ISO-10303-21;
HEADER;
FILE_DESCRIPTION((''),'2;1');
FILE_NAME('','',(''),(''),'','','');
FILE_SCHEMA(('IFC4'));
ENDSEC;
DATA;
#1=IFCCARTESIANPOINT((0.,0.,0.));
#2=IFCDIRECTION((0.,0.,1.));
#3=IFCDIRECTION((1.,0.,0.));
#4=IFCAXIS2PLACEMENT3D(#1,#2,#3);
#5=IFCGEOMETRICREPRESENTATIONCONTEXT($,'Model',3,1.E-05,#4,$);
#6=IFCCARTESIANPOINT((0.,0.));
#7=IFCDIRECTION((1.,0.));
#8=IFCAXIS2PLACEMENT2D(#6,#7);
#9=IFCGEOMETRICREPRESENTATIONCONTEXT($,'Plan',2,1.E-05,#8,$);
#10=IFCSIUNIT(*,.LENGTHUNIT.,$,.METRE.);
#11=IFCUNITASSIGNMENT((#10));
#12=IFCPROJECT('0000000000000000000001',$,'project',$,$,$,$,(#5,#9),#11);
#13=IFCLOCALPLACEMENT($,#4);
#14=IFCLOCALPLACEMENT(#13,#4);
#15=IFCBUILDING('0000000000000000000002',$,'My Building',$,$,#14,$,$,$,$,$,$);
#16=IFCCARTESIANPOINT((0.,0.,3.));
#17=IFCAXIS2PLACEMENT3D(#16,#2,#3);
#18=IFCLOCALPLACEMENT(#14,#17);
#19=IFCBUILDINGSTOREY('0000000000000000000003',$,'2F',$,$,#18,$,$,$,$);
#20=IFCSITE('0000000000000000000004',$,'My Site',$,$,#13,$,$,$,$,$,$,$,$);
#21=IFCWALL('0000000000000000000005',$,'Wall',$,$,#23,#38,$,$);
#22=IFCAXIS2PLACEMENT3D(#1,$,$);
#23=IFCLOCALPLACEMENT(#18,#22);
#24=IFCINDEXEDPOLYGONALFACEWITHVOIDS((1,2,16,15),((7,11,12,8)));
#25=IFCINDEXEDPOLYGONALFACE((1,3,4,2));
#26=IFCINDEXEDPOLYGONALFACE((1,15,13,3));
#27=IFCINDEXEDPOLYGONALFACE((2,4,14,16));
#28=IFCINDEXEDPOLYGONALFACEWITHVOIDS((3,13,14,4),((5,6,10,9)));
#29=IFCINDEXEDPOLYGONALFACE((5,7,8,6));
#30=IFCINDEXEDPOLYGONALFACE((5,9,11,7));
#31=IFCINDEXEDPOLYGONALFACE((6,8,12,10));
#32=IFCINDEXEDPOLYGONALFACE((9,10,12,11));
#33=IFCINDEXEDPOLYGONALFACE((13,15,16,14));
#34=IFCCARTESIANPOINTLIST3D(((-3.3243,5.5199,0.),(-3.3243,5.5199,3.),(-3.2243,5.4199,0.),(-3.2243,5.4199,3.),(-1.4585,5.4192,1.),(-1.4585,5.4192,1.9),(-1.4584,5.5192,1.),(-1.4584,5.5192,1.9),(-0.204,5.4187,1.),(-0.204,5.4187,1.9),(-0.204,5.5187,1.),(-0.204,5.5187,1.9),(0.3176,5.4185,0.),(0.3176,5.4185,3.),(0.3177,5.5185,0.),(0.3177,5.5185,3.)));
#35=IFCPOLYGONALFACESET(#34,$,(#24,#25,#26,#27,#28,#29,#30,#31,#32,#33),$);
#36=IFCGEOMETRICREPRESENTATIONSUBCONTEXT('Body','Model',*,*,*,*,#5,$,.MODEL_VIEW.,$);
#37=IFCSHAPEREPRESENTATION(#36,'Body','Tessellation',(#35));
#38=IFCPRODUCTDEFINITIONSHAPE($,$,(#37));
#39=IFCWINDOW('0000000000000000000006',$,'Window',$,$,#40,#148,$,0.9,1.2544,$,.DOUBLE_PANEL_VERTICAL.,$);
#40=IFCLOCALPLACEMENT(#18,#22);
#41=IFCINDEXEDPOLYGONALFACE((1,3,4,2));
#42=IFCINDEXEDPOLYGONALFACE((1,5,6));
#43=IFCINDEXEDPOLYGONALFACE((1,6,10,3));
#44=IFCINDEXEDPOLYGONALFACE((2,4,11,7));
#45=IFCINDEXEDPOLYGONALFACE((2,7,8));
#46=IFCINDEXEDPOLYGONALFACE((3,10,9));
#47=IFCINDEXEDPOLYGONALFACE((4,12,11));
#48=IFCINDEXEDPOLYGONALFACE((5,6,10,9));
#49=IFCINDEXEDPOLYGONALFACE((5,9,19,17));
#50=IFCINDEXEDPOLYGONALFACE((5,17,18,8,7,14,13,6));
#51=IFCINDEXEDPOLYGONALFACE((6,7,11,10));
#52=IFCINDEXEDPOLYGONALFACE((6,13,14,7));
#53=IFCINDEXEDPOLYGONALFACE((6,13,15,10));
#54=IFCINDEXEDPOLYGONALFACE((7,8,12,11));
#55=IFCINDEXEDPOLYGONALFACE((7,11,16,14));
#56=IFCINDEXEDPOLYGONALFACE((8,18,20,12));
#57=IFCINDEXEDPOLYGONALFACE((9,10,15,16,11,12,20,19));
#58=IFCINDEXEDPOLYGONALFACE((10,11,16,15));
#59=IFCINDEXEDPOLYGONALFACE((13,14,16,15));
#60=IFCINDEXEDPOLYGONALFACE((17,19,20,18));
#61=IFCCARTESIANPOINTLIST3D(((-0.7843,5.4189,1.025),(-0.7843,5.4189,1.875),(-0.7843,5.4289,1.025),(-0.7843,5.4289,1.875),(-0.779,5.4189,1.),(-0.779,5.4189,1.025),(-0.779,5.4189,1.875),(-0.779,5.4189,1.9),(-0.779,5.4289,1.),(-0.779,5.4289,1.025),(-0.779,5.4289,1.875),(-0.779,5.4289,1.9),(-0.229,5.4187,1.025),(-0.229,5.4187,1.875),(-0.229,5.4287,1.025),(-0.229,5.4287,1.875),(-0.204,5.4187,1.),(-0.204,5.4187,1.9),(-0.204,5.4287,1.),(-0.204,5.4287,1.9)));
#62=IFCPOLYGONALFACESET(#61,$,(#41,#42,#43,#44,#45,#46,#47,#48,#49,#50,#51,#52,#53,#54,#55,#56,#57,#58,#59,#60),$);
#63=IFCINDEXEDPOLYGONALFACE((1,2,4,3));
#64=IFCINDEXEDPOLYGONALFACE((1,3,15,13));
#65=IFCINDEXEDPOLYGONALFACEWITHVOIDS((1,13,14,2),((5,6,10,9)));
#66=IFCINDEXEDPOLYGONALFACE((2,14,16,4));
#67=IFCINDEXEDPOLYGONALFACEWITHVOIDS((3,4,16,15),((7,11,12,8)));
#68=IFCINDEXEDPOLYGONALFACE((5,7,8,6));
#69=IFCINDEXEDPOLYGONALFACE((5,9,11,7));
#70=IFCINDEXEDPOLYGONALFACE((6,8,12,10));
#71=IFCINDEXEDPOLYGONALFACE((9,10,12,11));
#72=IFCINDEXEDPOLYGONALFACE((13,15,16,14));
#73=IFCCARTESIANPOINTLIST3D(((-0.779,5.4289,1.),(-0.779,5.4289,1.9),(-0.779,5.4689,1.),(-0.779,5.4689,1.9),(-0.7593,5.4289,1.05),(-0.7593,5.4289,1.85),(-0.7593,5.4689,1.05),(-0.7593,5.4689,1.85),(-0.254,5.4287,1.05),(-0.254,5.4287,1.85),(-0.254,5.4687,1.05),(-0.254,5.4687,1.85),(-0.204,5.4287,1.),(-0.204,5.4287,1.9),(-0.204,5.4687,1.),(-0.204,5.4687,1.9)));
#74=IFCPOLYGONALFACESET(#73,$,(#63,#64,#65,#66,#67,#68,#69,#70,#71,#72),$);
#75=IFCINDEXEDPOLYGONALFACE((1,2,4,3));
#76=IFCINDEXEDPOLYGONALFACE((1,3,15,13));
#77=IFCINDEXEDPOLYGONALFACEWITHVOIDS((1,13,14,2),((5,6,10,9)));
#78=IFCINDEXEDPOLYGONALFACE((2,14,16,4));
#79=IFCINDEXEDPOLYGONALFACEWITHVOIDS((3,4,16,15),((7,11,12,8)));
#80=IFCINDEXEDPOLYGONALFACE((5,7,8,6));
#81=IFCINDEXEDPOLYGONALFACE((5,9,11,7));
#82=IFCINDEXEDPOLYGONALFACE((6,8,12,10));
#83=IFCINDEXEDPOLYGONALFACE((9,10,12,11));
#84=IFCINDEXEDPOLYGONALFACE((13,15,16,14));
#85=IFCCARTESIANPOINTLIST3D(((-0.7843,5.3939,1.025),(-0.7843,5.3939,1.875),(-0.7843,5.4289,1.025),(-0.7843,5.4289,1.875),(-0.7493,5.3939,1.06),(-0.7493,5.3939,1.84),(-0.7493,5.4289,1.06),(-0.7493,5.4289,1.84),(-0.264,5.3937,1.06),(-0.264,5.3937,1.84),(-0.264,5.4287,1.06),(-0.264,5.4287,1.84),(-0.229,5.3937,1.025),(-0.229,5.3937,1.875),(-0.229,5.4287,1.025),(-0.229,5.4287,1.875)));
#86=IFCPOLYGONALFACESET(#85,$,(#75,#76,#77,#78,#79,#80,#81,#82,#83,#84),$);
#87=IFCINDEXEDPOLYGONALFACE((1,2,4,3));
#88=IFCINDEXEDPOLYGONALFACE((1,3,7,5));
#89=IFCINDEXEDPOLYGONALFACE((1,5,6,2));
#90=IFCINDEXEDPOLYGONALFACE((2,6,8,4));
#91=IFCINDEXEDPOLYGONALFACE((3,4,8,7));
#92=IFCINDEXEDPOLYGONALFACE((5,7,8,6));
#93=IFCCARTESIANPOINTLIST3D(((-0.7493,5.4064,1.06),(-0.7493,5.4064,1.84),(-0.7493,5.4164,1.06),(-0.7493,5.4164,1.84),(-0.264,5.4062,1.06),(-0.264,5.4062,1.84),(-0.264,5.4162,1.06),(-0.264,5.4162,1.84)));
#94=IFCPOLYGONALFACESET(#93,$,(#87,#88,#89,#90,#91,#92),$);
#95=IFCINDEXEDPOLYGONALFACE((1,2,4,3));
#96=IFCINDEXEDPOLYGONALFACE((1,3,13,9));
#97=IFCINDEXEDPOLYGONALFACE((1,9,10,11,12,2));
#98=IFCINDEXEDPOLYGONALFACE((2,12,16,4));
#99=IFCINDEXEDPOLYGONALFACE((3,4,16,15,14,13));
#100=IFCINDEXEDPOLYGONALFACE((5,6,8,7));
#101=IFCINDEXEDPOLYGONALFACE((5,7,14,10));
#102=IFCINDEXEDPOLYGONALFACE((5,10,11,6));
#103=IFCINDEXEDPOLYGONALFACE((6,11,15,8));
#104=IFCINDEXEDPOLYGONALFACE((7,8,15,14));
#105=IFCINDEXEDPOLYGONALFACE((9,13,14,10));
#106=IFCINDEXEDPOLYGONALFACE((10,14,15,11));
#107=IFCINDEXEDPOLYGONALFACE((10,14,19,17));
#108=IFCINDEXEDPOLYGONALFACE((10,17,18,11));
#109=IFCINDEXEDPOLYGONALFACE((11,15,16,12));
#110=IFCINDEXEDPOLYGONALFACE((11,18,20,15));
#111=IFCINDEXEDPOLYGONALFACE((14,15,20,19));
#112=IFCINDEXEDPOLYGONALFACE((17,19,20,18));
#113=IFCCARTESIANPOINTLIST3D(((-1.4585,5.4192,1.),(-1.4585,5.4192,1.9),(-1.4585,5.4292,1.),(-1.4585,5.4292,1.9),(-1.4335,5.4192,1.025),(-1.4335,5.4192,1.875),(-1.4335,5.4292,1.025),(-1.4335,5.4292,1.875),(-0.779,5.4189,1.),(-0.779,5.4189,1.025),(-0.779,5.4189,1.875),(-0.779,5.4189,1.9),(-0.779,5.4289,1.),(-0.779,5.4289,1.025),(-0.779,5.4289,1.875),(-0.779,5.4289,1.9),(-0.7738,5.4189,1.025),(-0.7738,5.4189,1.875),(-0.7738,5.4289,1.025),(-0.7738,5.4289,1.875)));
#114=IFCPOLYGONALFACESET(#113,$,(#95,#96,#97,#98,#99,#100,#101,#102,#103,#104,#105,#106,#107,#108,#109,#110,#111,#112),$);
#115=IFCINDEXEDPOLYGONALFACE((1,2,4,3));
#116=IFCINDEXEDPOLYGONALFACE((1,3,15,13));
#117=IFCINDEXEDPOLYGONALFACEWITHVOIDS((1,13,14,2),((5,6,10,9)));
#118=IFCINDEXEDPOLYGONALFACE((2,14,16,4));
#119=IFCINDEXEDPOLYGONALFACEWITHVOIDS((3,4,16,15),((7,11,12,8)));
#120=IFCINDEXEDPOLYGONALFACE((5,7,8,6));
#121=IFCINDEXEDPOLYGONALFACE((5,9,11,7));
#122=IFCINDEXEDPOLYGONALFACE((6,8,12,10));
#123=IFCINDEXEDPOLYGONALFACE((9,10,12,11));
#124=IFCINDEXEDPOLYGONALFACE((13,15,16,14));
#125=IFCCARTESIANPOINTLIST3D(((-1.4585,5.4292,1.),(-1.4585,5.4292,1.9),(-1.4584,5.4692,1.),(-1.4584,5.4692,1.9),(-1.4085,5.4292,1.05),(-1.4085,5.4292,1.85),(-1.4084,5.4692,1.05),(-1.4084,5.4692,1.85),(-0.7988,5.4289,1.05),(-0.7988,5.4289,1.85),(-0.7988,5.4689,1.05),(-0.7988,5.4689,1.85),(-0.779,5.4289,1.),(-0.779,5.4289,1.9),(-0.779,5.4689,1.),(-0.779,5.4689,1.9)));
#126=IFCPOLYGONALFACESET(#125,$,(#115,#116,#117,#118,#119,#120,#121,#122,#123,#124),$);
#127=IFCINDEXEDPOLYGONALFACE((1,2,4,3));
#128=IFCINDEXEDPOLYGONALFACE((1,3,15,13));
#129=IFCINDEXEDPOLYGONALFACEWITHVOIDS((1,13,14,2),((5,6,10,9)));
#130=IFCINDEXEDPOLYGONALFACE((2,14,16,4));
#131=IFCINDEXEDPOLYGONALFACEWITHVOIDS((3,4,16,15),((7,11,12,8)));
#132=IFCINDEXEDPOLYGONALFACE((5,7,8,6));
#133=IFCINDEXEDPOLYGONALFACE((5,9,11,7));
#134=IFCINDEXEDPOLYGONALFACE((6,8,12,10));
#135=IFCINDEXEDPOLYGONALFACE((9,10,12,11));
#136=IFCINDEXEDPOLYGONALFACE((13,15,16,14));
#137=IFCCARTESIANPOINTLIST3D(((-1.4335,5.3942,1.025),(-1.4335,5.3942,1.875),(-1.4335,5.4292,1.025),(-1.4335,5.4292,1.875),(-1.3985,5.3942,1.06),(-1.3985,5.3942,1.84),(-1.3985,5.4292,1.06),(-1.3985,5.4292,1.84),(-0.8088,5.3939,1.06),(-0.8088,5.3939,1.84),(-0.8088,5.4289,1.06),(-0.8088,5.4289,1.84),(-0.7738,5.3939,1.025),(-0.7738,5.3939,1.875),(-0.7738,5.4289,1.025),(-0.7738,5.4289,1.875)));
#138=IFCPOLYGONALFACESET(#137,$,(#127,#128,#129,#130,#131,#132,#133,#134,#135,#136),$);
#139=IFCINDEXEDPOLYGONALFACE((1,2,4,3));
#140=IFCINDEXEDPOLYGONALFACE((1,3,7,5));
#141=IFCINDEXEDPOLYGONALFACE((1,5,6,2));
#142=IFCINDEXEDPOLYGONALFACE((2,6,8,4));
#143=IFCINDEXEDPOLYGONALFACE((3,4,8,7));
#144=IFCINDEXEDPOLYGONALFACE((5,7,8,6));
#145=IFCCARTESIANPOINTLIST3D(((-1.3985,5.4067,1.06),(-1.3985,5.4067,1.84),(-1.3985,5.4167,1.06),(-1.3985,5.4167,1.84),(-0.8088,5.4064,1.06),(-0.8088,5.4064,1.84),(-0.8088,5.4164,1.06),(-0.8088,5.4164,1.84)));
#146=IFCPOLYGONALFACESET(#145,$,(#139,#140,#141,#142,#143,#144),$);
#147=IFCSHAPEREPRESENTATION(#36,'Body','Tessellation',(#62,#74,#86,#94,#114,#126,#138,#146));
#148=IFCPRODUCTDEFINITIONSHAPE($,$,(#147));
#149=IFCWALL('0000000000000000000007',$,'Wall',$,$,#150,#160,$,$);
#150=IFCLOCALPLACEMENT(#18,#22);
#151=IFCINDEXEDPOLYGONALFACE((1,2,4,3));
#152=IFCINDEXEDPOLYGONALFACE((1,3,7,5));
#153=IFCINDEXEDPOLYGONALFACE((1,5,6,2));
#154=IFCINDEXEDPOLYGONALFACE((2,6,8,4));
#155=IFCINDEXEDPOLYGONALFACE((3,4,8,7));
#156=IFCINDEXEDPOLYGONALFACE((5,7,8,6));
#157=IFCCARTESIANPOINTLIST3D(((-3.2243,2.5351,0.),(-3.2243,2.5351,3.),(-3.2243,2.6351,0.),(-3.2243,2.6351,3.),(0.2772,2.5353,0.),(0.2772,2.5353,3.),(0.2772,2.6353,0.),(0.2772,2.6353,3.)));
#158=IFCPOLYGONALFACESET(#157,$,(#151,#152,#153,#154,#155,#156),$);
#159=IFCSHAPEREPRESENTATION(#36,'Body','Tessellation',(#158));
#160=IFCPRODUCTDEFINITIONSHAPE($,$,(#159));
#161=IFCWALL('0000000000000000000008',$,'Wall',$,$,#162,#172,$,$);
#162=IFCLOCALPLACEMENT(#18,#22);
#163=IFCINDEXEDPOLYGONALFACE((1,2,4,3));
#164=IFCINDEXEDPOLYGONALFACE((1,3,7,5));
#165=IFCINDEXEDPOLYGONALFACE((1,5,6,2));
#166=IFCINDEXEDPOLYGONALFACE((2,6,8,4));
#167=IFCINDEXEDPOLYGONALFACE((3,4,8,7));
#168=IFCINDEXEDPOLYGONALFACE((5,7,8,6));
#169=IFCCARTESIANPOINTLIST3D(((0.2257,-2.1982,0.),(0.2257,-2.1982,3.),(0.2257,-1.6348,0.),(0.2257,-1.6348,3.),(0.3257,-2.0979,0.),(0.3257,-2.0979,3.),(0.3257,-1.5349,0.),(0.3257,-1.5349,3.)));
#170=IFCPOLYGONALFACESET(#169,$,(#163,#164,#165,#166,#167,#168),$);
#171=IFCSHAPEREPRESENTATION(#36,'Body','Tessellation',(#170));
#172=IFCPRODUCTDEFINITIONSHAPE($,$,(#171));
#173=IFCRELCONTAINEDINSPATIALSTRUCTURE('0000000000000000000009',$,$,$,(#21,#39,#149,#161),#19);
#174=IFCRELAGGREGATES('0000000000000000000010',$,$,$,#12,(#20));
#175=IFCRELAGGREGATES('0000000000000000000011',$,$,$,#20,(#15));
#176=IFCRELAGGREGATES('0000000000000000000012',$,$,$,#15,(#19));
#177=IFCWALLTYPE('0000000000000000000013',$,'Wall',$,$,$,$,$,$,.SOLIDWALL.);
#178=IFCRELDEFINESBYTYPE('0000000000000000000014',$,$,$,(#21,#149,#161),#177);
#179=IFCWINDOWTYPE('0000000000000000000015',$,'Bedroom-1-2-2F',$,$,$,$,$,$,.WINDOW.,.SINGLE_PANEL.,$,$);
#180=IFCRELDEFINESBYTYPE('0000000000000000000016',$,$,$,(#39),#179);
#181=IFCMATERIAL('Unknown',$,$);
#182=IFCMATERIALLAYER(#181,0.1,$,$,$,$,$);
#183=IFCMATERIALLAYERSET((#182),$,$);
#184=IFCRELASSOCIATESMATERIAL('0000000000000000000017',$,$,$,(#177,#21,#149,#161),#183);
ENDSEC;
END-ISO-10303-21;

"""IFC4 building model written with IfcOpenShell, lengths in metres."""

from ifc_helpers import new_model, entity, si_unit, frame, origin_with_axes, origin_2d_with_axis, place, context, subcontext, project, spatial, line, indexed_curve, outline, extrude, shape, source, transform, mapped, material, layer, layer_set, layer_usage, type_object, type_shapes, element, fill, save


model = new_model("IFC4")

# Units and contexts
model_context = context("Model", 3, precision=1e-05, world=origin_with_axes())
plan_context = context("Plan", 2, precision=1e-05, world=origin_2d_with_axis())
body_context_1 = subcontext(model_context, "Body", "Model", "MODEL_VIEW")
body_context_2 = subcontext(plan_context, "Body", "Plan", "PLAN_VIEW")
ifc_project = project(units=[si_unit("LENGTHUNIT", "METRE")], contexts=[model_context, plan_context])

# Site, building, storey
site_placement = place(None, origin_with_axes())
site = spatial("IfcSite", under=ifc_project, at=site_placement, Name="My Site")
building_placement = place(site_placement, origin_with_axes())
building = spatial("IfcBuilding", under=site, at=building_placement, Name="My Building")
storey_placement = place(building_placement, frame((0.0, 0.0, 3.0), z_axis=(0.0, 0.0, 1.0), x_axis=(1.0, 0.0, 0.0)))
storey = spatial("IfcBuildingStorey", under=building, at=storey_placement, Name="2F")

# Shared definitions
ifc_material = material(Name="Unknown")
ifc_layer = layer(ifc_material, 0.1)
ifc_layer_set = layer_set([ifc_layer])
wall_type = type_object("IfcWallType", Name="Wall", PredefinedType="SOLIDWALL", material=ifc_layer_set)

# Wall, opening, window
ifc_layer_usage_1 = layer_usage(ifc_layer_set, "AXIS2", "POSITIVE", 0.0)
wall_1_placement = place(storey_placement, frame((-3.3243, 5.4199, 0.0), z_axis=(0.0, 0.0, 1.0), x_axis=(1.0, -0.000383, 0.0)))
wall_1 = element("IfcWall", 1, at=wall_1_placement, inside=storey, type_object=wall_type, material=ifc_layer_usage_1, Name="Wall", context=body_context_1, shape_type="SweptSolid", body=[
    extrude(outline(indexed_curve([(0.1, 0.0), (0.0, 0.1), (3.6419, 0.1), (3.6419, 0.0)], segments=[line(1, 2, 3, 4, 1)])), origin_with_axes(), (0.0, 0.0, 1.0), 3.0),
])
shared_shape_1 = source(origin_with_axes(), body_context_1, "Body", "SweptSolid", [
    extrude(outline(indexed_curve([(0.0, 0.0), (1.2544, 0.0), (1.2544, 0.9), (0.0, 0.9)], segments=[line(1, 2, 3, 4, 1)])), frame((0.0, -0.6, 0.0), z_axis=(0.0, -1.0, 0.0), x_axis=(1.0, 0.0, 0.0)), (0.0, 0.0, -1.0), 1.2),
])
opening_1_placement = place(wall_1_placement, frame((3.1202, 0.1, 1.0), z_axis=(0.0, 0.0, 1.0), x_axis=(-1.0, 0.0, 0.0)))
opening_1 = element("IfcOpeningElement", 2, at=opening_1_placement, cuts=wall_1, PredefinedType="OPENING", context=body_context_1, shape_type="MappedRepresentation", body=[
    mapped(shared_shape_1, transform((0.0, 0.0, 0.0), x_axis=(1.0, 0.0, 0.0), y_axis=(0.0, 1.0, 0.0), z_axis=(0.0, 0.0, 1.0), scale=1.0)),
])
window_type_1 = type_object("IfcWindowType", Name="Bedroom-1-2-2F", PartitioningType="SINGLE_PANEL", PredefinedType="WINDOW")
shared_shape_2 = source(origin_with_axes(), body_context_1, "Body", "SweptSolid", [
    extrude(outline(indexed_curve([(0.0, 0.0), (0.575, 0.0), (0.575, 0.9), (0.0, 0.9)], segments=[line(1, 2, 3, 4, 1)]), holes=[indexed_curve([(0.025, 0.025), (0.5803, 0.025), (0.5803, 0.875), (0.025, 0.875)], segments=[line(1, 2, 3, 4, 1)])]), frame((0.0, 0.09, 0.0), z_axis=(0.0, -1.0, 0.0), x_axis=(1.0, 0.0, 0.0)), (0.0, 0.0, -1.0), 0.01),
    extrude(outline(indexed_curve([(0.0, 0.0), (0.575, 0.0), (0.575, 0.9), (0.0, 0.9)], segments=[line(1, 2, 3, 4, 1)]), holes=[indexed_curve([(0.05, 0.05), (0.5553, 0.05), (0.5553, 0.85), (0.05, 0.85)], segments=[line(1, 2, 3, 4, 1)])]), frame((0.0, 0.05, 0.0), z_axis=(0.0, -1.0, 0.0), x_axis=(1.0, 0.0, 0.0)), (0.0, 0.0, -1.0), 0.04),
    extrude(outline(indexed_curve([(0.0, 0.0), (0.5553, 0.0), (0.5553, 0.85), (0.0, 0.85)], segments=[line(1, 2, 3, 4, 1)]), holes=[indexed_curve([(0.035, 0.035), (0.5203, 0.035), (0.5203, 0.815), (0.035, 0.815)], segments=[line(1, 2, 3, 4, 1)])]), frame((0.025, 0.09, 0.025), z_axis=(0.0, -1.0, 0.0), x_axis=(1.0, 0.0, 0.0)), (0.0, 0.0, -1.0), 0.035),
    extrude(outline(indexed_curve([(0.035, 0.035), (0.5203, 0.035), (0.5203, 0.815), (0.035, 0.815)], segments=[line(1, 2, 3, 4, 1)])), frame((0.025, 0.1025, 0.025), z_axis=(0.0, -1.0, 0.0), x_axis=(1.0, 0.0, 0.0)), (0.0, 0.0, -1.0), 0.01),
    extrude(outline(indexed_curve([(0.0, 0.0), (0.6794, 0.0), (0.6794, 0.9), (0.0, 0.9)], segments=[line(1, 2, 3, 4, 1)]), holes=[indexed_curve([(-0.0052, 0.025), (0.6544, 0.025), (0.6544, 0.875), (-0.0052, 0.875)], segments=[line(1, 2, 3, 4, 1)])]), frame((0.575, 0.09, 0.0), z_axis=(0.0, -1.0, 0.0), x_axis=(1.0, 0.0, 0.0)), (0.0, 0.0, -1.0), 0.01),
    extrude(outline(indexed_curve([(0.0, 0.0), (0.6794, 0.0), (0.6794, 0.9), (0.0, 0.9)], segments=[line(1, 2, 3, 4, 1)]), holes=[indexed_curve([(0.0198, 0.05), (0.6294, 0.05), (0.6294, 0.85), (0.0198, 0.85)], segments=[line(1, 2, 3, 4, 1)])]), frame((0.575, 0.05, 0.0), z_axis=(0.0, -1.0, 0.0), x_axis=(1.0, 0.0, 0.0)), (0.0, 0.0, -1.0), 0.04),
    extrude(outline(indexed_curve([(0.0, 0.0), (0.6596, 0.0), (0.6596, 0.85), (0.0, 0.85)], segments=[line(1, 2, 3, 4, 1)]), holes=[indexed_curve([(0.035, 0.035), (0.6246, 0.035), (0.6246, 0.815), (0.035, 0.815)], segments=[line(1, 2, 3, 4, 1)])]), frame((0.5698, 0.09, 0.025), z_axis=(0.0, -1.0, 0.0), x_axis=(1.0, 0.0, 0.0)), (0.0, 0.0, -1.0), 0.035),
    extrude(outline(indexed_curve([(0.035, 0.035), (0.6246, 0.035), (0.6246, 0.815), (0.035, 0.815)], segments=[line(1, 2, 3, 4, 1)])), frame((0.5698, 0.1025, 0.025), z_axis=(0.0, -1.0, 0.0), x_axis=(1.0, 0.0, 0.0)), (0.0, 0.0, -1.0), 0.01),
])
shared_shape_3 = source(origin_with_axes(), body_context_2, "Body", "Curve2D", [
    entity("IfcIndexedPolyCurve", entity("IfcCartesianPointList2D", [[0.05, 0.05], [0.5553, 0.05]])),
    entity("IfcIndexedPolyCurve", entity("IfcCartesianPointList2D", [[0.0, 0.1], [0.025, 0.1], [0.025, 0.09], [0.05, 0.09], [0.05, 0.05], [0.0, 0.05]]), [entity("IfcLineIndex", [1, 2, 3, 4, 5, 6, 1])]),
    entity("IfcIndexedPolyCurve", entity("IfcCartesianPointList2D", [[0.575, 0.1], [0.5803, 0.1], [0.5803, 0.09], [0.5553, 0.09], [0.5553, 0.05], [0.575, 0.05]])),
    entity("IfcIndexedPolyCurve", entity("IfcCartesianPointList2D", [[0.025, 0.09], [0.06, 0.09], [0.06, 0.125], [0.025, 0.125]]), [entity("IfcLineIndex", [1, 2, 3, 4, 1])]),
    entity("IfcIndexedPolyCurve", entity("IfcCartesianPointList2D", [[0.5803, 0.09], [0.5453, 0.09], [0.5453, 0.125], [0.5803, 0.125]]), [entity("IfcLineIndex", [1, 2, 3, 4, 1])]),
    entity("IfcIndexedPolyCurve", entity("IfcCartesianPointList2D", [[0.06, 0.09], [0.5453, 0.09]])),
    entity("IfcIndexedPolyCurve", entity("IfcCartesianPointList2D", [[0.06, 0.125], [0.5453, 0.125]])),
    entity("IfcIndexedPolyCurve", entity("IfcCartesianPointList2D", [[0.06, 0.1075], [0.5453, 0.1075]])),
    entity("IfcIndexedPolyCurve", entity("IfcCartesianPointList2D", [[0.5948, 0.05], [1.2044, 0.05]])),
    entity("IfcIndexedPolyCurve", entity("IfcCartesianPointList2D", [[0.575, 0.1], [0.5698, 0.1], [0.5698, 0.09], [0.5948, 0.09], [0.5948, 0.05], [0.575, 0.05]])),
    entity("IfcIndexedPolyCurve", entity("IfcCartesianPointList2D", [[1.2544, 0.1], [1.2294, 0.1], [1.2294, 0.09], [1.2044, 0.09], [1.2044, 0.05], [1.2544, 0.05]]), [entity("IfcLineIndex", [1, 2, 3, 4, 5, 6, 1])]),
    entity("IfcIndexedPolyCurve", entity("IfcCartesianPointList2D", [[0.5698, 0.09], [0.6048, 0.09], [0.6048, 0.125], [0.5698, 0.125]]), [entity("IfcLineIndex", [1, 2, 3, 4, 1])]),
    entity("IfcIndexedPolyCurve", entity("IfcCartesianPointList2D", [[1.2294, 0.09], [1.1944, 0.09], [1.1944, 0.125], [1.2294, 0.125]]), [entity("IfcLineIndex", [1, 2, 3, 4, 1])]),
    entity("IfcIndexedPolyCurve", entity("IfcCartesianPointList2D", [[0.6048, 0.09], [1.1944, 0.09]])),
    entity("IfcIndexedPolyCurve", entity("IfcCartesianPointList2D", [[0.6048, 0.125], [1.1944, 0.125]])),
    entity("IfcIndexedPolyCurve", entity("IfcCartesianPointList2D", [[0.6048, 0.1075], [1.1944, 0.1075]])),
])
type_shapes(window_type_1, [shared_shape_2, shared_shape_3])
window_1_placement = place(opening_1_placement, origin_with_axes())
window_1 = element("IfcWindow", 3, at=window_1_placement, inside=storey, type_object=window_type_1, Name="Window", OverallHeight=0.9, OverallWidth=1.2544, PartitioningType="DOUBLE_PANEL_VERTICAL", shapes=[
    shape(body_context_1, "Body", "MappedRepresentation", [mapped(shared_shape_2, transform((0.0, 0.0, 0.0), x_axis=(1.0, 0.0, 0.0), y_axis=(0.0, 1.0, 0.0), z_axis=(0.0, 0.0, 1.0), scale=1.0))]),
    shape(body_context_2, "Body", "MappedRepresentation", [mapped(shared_shape_3, transform((0.0, 0.0, 0.0), x_axis=(1.0, 0.0, 0.0), y_axis=(0.0, 1.0, 0.0), z_axis=(0.0, 0.0, 1.0), scale=1.0))]),
])
fill(opening_1, window_1)

# Walls
ifc_layer_usage_2 = layer_usage(ifc_layer_set, "AXIS2", "POSITIVE", 0.0)
wall_2_placement = place(storey_placement, frame((-3.2243, 2.5351, 0.0), z_axis=(0.0, 0.0, 1.0), x_axis=(1.0, 0.000051, 0.0)))
element("IfcWall", 4, at=wall_2_placement, inside=storey, type_object=wall_type, material=ifc_layer_usage_2, Name="Wall", context=body_context_1, shape_type="SweptSolid", body=[
    extrude(outline(indexed_curve([(0.0, 0.0), (0.0, 0.1), (3.5015, 0.1), (3.5015, 0.0)], segments=[line(1, 2, 3, 4, 1)])), origin_with_axes(), (0.0, 0.0, 1.0), 3.0),
])
ifc_layer_usage_3 = layer_usage(ifc_layer_set, "AXIS2", "POSITIVE", 0.0)
wall_3_placement = place(storey_placement, frame((0.2257, -1.6348, 0.0), z_axis=(0.0, 0.0, 1.0), x_axis=(0.0, -1.0, 0.0)))
element("IfcWall", 5, at=wall_3_placement, inside=storey, type_object=wall_type, material=ifc_layer_usage_3, Name="Wall", context=body_context_1, shape_type="SweptSolid", body=[
    extrude(outline(indexed_curve([(0.0, 0.0), (-0.0999, 0.1), (0.4631, 0.1), (0.5634, 0.0)], segments=[line(1, 2, 3, 4, 1)])), origin_with_axes(), (0.0, 0.0, 1.0), 3.0),
])

save(model, "model.ifc")
